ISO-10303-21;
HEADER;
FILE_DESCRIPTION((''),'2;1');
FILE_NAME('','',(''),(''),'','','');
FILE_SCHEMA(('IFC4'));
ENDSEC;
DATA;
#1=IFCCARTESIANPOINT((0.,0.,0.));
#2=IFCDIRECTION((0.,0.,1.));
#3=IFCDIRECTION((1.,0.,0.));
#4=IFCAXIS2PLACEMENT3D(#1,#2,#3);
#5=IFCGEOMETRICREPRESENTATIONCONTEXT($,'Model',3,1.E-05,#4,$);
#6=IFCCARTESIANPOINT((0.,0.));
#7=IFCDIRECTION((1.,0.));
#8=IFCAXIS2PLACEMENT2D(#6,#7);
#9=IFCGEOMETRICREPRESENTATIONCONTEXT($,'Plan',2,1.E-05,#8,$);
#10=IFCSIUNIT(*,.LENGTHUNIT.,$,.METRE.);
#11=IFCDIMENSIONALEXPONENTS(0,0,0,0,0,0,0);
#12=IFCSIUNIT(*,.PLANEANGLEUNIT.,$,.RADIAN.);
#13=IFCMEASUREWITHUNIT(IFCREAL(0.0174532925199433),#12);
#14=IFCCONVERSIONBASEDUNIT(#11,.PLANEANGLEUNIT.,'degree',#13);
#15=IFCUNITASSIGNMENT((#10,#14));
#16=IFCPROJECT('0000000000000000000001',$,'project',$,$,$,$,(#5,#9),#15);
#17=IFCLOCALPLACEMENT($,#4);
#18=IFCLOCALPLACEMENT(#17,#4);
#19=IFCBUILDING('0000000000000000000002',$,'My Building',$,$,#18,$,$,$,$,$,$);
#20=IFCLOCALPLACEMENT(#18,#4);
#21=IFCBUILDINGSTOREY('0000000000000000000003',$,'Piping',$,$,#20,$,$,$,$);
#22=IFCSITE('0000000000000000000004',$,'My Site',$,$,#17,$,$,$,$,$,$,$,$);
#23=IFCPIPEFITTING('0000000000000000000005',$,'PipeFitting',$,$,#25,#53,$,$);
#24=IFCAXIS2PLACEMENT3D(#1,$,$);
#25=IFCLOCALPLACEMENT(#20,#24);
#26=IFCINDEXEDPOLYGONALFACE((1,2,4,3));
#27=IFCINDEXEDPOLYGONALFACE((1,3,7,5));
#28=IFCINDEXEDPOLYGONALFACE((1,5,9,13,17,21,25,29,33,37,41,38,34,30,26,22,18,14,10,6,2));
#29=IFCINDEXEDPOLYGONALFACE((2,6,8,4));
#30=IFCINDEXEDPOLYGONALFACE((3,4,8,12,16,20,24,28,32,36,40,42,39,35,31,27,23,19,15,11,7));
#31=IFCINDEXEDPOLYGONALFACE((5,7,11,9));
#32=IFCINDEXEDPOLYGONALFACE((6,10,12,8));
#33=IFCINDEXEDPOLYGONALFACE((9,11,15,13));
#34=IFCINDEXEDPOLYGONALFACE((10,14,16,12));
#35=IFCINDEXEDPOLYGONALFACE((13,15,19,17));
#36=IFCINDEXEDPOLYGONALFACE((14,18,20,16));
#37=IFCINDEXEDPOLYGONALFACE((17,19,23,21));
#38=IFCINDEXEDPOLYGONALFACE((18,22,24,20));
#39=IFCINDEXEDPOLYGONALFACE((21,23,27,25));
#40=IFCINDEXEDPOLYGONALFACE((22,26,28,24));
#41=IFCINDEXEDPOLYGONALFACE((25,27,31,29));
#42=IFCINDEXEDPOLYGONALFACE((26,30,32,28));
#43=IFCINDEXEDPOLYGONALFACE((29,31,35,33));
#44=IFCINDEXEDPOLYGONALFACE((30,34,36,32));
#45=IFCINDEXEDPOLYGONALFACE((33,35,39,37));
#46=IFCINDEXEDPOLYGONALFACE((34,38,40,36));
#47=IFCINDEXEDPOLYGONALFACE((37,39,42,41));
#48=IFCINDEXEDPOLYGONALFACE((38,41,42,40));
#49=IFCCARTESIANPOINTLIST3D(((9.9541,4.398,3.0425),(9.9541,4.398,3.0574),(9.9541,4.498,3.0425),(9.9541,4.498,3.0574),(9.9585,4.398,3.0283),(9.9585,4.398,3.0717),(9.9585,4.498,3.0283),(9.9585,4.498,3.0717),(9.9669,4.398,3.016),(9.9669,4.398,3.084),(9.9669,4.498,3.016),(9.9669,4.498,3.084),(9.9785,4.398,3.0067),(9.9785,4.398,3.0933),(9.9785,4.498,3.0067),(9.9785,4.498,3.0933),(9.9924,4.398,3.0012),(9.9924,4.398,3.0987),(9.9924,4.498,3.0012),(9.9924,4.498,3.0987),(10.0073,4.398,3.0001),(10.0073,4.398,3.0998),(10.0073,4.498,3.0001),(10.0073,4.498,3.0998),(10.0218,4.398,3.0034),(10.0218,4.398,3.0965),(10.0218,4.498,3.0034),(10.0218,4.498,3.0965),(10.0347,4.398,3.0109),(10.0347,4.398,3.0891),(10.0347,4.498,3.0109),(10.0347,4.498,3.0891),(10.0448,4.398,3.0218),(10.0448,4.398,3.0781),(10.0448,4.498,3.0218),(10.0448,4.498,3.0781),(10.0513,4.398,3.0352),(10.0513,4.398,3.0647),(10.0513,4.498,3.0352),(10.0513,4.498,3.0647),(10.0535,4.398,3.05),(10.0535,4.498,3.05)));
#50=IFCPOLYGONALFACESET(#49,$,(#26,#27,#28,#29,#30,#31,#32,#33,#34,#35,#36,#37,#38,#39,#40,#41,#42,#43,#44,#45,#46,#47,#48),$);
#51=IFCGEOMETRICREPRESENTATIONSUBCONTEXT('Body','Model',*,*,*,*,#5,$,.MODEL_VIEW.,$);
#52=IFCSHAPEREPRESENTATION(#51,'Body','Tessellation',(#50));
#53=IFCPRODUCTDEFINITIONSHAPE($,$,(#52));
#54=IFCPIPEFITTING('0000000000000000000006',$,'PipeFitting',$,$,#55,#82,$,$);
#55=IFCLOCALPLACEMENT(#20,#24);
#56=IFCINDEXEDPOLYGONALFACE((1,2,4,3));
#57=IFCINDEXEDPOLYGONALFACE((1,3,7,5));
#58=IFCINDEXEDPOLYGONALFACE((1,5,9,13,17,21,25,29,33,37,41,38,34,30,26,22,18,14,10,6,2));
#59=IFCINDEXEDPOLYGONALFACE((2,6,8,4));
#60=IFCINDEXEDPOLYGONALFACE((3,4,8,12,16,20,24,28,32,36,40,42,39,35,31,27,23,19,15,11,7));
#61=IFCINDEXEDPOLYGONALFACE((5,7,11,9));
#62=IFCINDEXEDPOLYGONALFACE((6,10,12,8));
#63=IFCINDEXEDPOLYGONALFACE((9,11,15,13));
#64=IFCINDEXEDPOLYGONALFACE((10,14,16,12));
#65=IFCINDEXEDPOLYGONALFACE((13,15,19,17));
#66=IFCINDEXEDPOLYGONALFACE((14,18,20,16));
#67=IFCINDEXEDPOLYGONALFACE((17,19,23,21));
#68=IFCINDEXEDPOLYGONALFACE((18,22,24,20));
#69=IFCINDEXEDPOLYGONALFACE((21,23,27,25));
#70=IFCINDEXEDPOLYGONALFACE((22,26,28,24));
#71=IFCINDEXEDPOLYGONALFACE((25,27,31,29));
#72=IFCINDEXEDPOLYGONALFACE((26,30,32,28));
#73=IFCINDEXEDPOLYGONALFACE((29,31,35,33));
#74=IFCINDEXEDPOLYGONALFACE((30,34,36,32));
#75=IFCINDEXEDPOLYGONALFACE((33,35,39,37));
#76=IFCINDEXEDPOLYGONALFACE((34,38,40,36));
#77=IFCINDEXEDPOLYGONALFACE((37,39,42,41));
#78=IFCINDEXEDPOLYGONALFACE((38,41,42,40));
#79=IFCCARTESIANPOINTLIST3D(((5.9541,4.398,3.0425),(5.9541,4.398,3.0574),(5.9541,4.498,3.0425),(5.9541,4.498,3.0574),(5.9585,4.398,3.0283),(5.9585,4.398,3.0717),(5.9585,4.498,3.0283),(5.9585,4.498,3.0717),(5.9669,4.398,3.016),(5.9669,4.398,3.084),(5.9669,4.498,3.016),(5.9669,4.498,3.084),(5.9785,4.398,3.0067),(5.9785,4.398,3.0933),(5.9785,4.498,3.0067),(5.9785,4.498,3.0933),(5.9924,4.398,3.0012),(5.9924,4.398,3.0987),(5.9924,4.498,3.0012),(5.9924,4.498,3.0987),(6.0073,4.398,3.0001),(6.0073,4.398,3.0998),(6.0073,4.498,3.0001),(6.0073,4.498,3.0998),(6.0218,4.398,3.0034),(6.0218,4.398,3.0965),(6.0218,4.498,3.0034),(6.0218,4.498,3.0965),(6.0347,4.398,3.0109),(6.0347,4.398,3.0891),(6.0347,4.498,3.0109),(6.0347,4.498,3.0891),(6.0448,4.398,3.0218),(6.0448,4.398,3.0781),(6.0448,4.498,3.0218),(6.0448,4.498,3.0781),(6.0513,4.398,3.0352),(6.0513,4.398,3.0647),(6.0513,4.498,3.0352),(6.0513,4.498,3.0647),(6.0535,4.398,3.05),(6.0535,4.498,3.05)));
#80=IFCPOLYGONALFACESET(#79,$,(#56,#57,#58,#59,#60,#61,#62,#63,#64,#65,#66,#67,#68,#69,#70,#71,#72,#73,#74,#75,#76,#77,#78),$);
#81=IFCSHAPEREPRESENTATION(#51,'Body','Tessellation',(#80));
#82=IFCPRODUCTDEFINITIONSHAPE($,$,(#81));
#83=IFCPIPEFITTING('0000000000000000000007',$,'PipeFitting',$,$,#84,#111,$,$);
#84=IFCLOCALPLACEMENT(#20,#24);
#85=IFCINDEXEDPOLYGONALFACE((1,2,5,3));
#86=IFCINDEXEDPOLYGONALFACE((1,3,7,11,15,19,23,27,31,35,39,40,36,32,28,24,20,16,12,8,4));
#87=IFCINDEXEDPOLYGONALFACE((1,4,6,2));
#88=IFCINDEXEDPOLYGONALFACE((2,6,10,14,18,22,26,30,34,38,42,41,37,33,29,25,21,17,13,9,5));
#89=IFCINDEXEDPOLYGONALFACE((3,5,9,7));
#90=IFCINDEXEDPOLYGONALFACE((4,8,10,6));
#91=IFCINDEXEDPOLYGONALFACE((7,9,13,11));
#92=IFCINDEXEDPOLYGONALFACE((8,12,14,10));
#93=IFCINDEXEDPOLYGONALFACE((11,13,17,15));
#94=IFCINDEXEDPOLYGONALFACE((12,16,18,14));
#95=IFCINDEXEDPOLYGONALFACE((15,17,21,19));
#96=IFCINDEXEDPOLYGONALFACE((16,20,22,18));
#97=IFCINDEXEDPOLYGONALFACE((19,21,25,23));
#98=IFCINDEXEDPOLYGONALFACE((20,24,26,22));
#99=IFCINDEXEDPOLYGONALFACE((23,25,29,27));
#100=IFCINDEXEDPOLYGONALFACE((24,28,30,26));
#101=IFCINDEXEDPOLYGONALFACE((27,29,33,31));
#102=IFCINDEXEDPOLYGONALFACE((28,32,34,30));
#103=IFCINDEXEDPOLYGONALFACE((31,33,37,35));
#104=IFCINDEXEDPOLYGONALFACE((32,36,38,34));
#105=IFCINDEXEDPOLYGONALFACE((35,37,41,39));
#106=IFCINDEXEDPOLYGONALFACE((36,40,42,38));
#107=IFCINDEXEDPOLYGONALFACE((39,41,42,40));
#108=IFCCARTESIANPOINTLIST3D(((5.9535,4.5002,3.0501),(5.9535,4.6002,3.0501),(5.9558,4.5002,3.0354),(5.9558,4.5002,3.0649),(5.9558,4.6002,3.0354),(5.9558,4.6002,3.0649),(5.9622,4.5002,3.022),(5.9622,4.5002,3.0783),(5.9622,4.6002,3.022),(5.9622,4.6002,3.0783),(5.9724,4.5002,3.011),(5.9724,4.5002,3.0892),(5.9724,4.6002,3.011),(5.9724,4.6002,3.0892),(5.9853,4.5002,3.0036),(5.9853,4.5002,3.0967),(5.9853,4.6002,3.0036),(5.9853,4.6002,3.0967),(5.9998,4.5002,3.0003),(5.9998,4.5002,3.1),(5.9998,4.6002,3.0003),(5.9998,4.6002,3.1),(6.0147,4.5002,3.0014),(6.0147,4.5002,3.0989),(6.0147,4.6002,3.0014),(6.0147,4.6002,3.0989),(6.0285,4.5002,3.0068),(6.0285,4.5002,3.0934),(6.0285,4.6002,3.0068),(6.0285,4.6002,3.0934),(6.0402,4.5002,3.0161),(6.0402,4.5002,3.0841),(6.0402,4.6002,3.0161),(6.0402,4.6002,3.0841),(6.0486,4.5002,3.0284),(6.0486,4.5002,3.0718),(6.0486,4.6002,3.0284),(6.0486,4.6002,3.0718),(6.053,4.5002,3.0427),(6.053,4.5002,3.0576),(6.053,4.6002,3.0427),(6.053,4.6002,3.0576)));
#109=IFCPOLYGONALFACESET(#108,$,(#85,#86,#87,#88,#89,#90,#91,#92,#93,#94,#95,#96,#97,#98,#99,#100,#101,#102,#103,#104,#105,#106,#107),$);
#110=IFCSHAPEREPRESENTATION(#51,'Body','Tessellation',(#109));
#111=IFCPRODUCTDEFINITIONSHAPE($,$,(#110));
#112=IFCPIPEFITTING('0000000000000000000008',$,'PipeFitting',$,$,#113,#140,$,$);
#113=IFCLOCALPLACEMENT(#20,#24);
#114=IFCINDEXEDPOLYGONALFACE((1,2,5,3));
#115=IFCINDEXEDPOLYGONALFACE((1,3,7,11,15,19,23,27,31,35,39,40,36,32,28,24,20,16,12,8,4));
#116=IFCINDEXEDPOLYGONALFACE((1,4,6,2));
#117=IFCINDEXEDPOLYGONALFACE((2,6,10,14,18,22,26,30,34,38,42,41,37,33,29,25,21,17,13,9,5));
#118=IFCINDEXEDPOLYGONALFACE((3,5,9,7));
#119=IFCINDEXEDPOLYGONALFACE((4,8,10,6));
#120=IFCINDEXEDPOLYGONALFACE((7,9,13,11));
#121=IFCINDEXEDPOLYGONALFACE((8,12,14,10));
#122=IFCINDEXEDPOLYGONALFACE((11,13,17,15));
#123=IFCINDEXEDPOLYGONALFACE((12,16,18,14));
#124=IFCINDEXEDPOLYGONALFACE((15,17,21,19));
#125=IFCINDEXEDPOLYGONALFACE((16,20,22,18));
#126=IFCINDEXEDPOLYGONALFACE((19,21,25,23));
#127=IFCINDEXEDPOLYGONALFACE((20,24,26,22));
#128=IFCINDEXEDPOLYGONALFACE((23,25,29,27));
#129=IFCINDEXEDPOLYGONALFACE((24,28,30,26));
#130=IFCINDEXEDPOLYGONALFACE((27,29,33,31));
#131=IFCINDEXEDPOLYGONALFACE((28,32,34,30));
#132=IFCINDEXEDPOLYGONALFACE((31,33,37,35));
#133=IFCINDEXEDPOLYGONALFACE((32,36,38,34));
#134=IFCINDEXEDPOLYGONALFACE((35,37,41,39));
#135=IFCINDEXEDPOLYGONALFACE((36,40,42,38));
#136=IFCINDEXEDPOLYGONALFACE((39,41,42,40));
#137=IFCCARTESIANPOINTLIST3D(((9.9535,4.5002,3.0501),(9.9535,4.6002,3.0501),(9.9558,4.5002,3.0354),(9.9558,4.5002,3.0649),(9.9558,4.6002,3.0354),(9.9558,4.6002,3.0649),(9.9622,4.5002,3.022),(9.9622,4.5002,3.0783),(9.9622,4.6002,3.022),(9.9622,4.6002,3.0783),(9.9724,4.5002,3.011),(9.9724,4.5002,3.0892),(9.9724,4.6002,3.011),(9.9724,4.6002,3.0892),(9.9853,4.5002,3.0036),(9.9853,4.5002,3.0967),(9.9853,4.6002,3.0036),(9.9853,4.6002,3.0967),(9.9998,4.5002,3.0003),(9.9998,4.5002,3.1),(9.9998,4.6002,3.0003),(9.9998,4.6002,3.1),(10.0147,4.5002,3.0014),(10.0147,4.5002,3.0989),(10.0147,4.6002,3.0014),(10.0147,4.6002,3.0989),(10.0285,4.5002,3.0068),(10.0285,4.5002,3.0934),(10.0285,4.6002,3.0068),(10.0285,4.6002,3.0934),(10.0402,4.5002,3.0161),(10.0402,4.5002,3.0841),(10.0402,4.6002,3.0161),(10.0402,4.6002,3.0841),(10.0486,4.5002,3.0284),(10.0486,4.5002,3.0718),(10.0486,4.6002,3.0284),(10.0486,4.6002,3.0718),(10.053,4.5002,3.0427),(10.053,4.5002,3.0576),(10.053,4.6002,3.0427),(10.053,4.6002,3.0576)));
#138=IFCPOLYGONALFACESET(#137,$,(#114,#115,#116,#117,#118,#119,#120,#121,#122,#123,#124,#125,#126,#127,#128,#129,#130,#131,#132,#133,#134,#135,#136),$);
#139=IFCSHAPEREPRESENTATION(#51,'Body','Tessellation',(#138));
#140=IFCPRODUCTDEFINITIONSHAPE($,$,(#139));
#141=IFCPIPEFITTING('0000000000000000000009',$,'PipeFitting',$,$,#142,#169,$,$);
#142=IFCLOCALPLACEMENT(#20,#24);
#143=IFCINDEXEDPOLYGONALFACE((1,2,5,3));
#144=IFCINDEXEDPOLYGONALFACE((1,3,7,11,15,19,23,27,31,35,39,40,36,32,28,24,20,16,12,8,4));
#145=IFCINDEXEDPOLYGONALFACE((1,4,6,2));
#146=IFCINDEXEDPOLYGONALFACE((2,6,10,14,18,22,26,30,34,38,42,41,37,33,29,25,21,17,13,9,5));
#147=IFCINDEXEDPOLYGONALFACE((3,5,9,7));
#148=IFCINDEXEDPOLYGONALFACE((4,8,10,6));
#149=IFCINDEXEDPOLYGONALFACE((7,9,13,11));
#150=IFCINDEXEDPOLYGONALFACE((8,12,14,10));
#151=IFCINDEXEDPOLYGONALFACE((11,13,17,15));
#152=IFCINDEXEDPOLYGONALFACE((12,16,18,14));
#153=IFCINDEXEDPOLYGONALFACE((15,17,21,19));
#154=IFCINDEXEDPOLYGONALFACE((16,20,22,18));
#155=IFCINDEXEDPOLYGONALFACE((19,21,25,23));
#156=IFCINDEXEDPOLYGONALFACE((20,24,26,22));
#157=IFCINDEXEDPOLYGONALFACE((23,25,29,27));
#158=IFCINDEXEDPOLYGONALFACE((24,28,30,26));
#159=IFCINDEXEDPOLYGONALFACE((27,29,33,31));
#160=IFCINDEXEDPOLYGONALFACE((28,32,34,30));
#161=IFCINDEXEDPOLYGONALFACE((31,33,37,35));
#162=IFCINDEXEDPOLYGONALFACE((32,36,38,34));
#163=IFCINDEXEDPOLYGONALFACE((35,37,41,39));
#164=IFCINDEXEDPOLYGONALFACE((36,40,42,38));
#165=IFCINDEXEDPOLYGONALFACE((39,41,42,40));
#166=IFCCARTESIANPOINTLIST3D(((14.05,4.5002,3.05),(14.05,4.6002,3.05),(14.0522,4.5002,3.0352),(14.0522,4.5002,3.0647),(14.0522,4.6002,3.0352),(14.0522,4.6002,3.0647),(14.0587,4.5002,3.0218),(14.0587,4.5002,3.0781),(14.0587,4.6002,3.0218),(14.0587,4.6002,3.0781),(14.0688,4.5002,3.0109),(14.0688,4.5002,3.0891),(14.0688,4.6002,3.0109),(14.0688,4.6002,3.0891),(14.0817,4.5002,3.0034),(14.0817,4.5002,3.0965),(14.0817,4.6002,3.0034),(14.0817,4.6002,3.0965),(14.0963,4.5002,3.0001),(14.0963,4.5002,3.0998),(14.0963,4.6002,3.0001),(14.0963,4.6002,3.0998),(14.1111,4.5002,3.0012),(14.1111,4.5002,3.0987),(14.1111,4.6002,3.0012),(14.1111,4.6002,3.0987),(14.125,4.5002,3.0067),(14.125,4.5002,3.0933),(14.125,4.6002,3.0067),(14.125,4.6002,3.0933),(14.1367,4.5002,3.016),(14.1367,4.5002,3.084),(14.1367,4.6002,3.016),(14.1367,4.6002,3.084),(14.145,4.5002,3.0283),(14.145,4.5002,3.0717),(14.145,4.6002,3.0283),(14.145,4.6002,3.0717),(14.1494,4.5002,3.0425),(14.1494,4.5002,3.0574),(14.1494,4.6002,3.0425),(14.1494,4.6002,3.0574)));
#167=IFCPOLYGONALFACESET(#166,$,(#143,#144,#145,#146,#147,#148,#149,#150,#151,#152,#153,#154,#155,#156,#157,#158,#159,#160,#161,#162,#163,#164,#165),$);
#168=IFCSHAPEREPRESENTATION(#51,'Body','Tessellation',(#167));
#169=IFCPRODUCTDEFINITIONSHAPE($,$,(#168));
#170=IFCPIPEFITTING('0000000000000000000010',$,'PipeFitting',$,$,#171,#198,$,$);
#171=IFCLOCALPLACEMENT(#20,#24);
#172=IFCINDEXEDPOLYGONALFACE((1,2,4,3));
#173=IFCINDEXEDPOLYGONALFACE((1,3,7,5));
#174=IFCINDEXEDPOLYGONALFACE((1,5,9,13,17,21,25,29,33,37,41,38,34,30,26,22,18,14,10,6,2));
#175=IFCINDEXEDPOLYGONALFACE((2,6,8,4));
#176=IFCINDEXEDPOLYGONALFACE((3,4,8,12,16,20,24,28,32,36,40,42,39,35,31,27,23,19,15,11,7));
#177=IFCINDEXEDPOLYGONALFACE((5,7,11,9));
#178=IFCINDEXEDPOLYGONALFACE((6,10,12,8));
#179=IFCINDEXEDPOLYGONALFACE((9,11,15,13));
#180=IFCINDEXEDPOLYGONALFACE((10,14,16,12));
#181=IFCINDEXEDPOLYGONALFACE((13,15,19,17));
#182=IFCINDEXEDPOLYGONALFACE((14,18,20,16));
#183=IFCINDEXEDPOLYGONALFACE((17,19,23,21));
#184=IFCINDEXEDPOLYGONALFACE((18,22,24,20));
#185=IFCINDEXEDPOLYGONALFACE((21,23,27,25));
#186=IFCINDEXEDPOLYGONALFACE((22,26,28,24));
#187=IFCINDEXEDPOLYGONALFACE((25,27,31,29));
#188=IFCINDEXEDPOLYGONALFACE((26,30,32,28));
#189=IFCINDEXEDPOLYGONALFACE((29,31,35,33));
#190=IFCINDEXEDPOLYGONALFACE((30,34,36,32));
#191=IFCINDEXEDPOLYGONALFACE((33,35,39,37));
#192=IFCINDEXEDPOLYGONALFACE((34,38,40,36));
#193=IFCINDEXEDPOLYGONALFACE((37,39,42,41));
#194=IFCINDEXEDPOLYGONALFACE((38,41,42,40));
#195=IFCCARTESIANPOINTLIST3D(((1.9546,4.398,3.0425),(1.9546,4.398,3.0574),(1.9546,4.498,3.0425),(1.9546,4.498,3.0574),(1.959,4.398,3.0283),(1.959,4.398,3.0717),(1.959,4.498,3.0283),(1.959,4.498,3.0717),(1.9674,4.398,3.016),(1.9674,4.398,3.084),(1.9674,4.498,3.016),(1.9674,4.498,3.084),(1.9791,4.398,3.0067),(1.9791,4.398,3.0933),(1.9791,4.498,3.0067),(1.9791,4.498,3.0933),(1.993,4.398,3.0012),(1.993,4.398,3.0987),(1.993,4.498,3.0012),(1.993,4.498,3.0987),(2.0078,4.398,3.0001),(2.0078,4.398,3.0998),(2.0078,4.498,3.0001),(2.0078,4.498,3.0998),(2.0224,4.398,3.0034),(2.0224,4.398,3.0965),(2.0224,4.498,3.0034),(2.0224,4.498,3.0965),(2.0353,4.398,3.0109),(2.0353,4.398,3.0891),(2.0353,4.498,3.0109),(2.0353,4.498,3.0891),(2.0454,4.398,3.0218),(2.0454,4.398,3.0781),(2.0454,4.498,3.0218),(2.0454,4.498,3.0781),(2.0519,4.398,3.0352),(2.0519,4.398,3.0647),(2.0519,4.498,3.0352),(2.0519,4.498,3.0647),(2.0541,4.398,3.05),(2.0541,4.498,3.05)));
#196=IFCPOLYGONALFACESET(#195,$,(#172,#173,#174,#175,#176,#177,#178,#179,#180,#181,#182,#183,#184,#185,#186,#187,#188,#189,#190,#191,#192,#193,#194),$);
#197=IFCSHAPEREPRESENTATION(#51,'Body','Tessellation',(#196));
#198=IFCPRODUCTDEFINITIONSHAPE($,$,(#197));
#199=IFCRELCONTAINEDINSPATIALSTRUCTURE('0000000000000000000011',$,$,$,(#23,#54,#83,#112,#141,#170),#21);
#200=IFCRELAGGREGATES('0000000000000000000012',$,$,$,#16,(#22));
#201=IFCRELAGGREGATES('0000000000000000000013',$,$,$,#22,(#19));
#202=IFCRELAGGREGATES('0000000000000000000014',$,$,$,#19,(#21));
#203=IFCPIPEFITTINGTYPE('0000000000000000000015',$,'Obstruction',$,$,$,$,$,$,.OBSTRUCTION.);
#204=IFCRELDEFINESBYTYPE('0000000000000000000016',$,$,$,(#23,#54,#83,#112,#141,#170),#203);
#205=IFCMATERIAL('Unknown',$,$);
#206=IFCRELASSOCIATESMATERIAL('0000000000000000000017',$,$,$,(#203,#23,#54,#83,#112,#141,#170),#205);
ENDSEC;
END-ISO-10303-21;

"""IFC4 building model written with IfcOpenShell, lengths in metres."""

from ifc_helpers import new_model, entity, si_unit, converted_unit, frame, origin_with_axes, origin_2d_with_axis, place, context, subcontext, project, spatial, circle, extrude, material, material_profile, profile_set, profile_usage, type_object, element, save


model = new_model("IFC4")

# Units and contexts
model_context = context("Model", 3, precision=1e-05, world=origin_with_axes())
plan_context = context("Plan", 2, precision=1e-05, world=origin_2d_with_axis())
body_context = subcontext(model_context, "Body", "Model", "MODEL_VIEW")
ifc_project = project(units=[si_unit("LENGTHUNIT", "METRE"), converted_unit("PLANEANGLEUNIT", "degree", entity("IfcReal", 0.0174532925199433), si_unit("PLANEANGLEUNIT", "RADIAN"), dimensions=[0, 0, 0, 0, 0, 0, 0])], contexts=[model_context, plan_context])

# Site, building, storey
site_placement = place(None, origin_with_axes())
site = spatial("IfcSite", under=ifc_project, at=site_placement, Name="My Site")
building_placement = place(site_placement, origin_with_axes())
building = spatial("IfcBuilding", under=site, at=building_placement, Name="My Building")
storey_placement = place(building_placement, origin_with_axes())
storey = spatial("IfcBuildingStorey", under=building, at=storey_placement, Name="Piping")

# Shared definitions
ifc_material = material(Name="Unknown")

# Pipe fittings
ifc_material_profile_1 = material_profile(ifc_material, circle(Radius=0.05))
ifc_profile_set_1 = profile_set([ifc_material_profile_1])
pipe_fitting_type_1 = type_object("IfcPipeFittingType", Name="Obstruction", PredefinedType="OBSTRUCTION", material=ifc_profile_set_1)
ifc_profile_usage_1 = profile_usage(ifc_profile_set_1, cardinal=5)
pipe_fitting_1_placement = place(storey_placement, frame((10.0035, 4.398, 3.05), z_axis=(0.0, 1.0, -0.000001), x_axis=(1.0, 0.0, 0.000001)))
element("IfcPipeFitting", 1, at=pipe_fitting_1_placement, inside=storey, type_object=pipe_fitting_type_1, material=ifc_profile_usage_1, Name="PipeFitting", context=body_context, shape_type="SweptSolid", body=[
    extrude(circle(Radius=0.05), origin_with_axes(), (0.0, 0.0, 1.0), 0.1),
])
ifc_profile_usage_2 = profile_usage(ifc_profile_set_1, cardinal=5)
pipe_fitting_2_placement = place(storey_placement, frame((6.0035, 4.398, 3.05), z_axis=(0.0, 1.0, -0.000001), x_axis=(1.0, 0.0, 0.000001)))
element("IfcPipeFitting", 2, at=pipe_fitting_2_placement, inside=storey, type_object=pipe_fitting_type_1, material=ifc_profile_usage_2, Name="PipeFitting", context=body_context, shape_type="SweptSolid", body=[
    extrude(circle(Radius=0.05), origin_with_axes(), (0.0, 0.0, 1.0), 0.1),
])
ifc_profile_usage_3 = profile_usage(ifc_profile_set_1, cardinal=5)
pipe_fitting_3_placement = place(storey_placement, frame((6.0035, 4.6002, 3.0501), z_axis=(0.0, -1.0, -0.000001), x_axis=(-1.0, 0.0, 0.000001)))
element("IfcPipeFitting", 3, at=pipe_fitting_3_placement, inside=storey, type_object=pipe_fitting_type_1, material=ifc_profile_usage_3, Name="PipeFitting", context=body_context, shape_type="SweptSolid", body=[
    extrude(circle(Radius=0.05), origin_with_axes(), (0.0, 0.0, 1.0), 0.1),
])
ifc_profile_usage_4 = profile_usage(ifc_profile_set_1, cardinal=5)
pipe_fitting_4_placement = place(storey_placement, frame((10.0035, 4.6002, 3.0501), z_axis=(0.0, -1.0, -0.000001), x_axis=(-1.0, 0.0, 0.000001)))
element("IfcPipeFitting", 4, at=pipe_fitting_4_placement, inside=storey, type_object=pipe_fitting_type_1, material=ifc_profile_usage_4, Name="PipeFitting", context=body_context, shape_type="SweptSolid", body=[
    extrude(circle(Radius=0.05), origin_with_axes(), (0.0, 0.0, 1.0), 0.1),
])
ifc_profile_usage_5 = profile_usage(ifc_profile_set_1, cardinal=5)
pipe_fitting_5_placement = place(storey_placement, frame((14.1, 4.6002, 3.05), z_axis=(0.0, -1.0, 0.0), x_axis=(-1.0, 0.0, 0.000001)))
element("IfcPipeFitting", 5, at=pipe_fitting_5_placement, inside=storey, type_object=pipe_fitting_type_1, material=ifc_profile_usage_5, Name="PipeFitting", context=body_context, shape_type="SweptSolid", body=[
    extrude(circle(Radius=0.05), origin_with_axes(), (0.0, 0.0, 1.0), 0.1),
])
ifc_profile_usage_6 = profile_usage(ifc_profile_set_1, cardinal=5)
pipe_fitting_6_placement = place(storey_placement, frame((2.0041, 4.398, 3.05), z_axis=(0.0, 1.0, -0.000001), x_axis=(1.0, 0.0, 0.000001)))
element("IfcPipeFitting", 6, at=pipe_fitting_6_placement, inside=storey, type_object=pipe_fitting_type_1, material=ifc_profile_usage_6, Name="PipeFitting", context=body_context, shape_type="SweptSolid", body=[
    extrude(circle(Radius=0.05), origin_with_axes(), (0.0, 0.0, 1.0), 0.1),
])

save(model, "model.ifc")
